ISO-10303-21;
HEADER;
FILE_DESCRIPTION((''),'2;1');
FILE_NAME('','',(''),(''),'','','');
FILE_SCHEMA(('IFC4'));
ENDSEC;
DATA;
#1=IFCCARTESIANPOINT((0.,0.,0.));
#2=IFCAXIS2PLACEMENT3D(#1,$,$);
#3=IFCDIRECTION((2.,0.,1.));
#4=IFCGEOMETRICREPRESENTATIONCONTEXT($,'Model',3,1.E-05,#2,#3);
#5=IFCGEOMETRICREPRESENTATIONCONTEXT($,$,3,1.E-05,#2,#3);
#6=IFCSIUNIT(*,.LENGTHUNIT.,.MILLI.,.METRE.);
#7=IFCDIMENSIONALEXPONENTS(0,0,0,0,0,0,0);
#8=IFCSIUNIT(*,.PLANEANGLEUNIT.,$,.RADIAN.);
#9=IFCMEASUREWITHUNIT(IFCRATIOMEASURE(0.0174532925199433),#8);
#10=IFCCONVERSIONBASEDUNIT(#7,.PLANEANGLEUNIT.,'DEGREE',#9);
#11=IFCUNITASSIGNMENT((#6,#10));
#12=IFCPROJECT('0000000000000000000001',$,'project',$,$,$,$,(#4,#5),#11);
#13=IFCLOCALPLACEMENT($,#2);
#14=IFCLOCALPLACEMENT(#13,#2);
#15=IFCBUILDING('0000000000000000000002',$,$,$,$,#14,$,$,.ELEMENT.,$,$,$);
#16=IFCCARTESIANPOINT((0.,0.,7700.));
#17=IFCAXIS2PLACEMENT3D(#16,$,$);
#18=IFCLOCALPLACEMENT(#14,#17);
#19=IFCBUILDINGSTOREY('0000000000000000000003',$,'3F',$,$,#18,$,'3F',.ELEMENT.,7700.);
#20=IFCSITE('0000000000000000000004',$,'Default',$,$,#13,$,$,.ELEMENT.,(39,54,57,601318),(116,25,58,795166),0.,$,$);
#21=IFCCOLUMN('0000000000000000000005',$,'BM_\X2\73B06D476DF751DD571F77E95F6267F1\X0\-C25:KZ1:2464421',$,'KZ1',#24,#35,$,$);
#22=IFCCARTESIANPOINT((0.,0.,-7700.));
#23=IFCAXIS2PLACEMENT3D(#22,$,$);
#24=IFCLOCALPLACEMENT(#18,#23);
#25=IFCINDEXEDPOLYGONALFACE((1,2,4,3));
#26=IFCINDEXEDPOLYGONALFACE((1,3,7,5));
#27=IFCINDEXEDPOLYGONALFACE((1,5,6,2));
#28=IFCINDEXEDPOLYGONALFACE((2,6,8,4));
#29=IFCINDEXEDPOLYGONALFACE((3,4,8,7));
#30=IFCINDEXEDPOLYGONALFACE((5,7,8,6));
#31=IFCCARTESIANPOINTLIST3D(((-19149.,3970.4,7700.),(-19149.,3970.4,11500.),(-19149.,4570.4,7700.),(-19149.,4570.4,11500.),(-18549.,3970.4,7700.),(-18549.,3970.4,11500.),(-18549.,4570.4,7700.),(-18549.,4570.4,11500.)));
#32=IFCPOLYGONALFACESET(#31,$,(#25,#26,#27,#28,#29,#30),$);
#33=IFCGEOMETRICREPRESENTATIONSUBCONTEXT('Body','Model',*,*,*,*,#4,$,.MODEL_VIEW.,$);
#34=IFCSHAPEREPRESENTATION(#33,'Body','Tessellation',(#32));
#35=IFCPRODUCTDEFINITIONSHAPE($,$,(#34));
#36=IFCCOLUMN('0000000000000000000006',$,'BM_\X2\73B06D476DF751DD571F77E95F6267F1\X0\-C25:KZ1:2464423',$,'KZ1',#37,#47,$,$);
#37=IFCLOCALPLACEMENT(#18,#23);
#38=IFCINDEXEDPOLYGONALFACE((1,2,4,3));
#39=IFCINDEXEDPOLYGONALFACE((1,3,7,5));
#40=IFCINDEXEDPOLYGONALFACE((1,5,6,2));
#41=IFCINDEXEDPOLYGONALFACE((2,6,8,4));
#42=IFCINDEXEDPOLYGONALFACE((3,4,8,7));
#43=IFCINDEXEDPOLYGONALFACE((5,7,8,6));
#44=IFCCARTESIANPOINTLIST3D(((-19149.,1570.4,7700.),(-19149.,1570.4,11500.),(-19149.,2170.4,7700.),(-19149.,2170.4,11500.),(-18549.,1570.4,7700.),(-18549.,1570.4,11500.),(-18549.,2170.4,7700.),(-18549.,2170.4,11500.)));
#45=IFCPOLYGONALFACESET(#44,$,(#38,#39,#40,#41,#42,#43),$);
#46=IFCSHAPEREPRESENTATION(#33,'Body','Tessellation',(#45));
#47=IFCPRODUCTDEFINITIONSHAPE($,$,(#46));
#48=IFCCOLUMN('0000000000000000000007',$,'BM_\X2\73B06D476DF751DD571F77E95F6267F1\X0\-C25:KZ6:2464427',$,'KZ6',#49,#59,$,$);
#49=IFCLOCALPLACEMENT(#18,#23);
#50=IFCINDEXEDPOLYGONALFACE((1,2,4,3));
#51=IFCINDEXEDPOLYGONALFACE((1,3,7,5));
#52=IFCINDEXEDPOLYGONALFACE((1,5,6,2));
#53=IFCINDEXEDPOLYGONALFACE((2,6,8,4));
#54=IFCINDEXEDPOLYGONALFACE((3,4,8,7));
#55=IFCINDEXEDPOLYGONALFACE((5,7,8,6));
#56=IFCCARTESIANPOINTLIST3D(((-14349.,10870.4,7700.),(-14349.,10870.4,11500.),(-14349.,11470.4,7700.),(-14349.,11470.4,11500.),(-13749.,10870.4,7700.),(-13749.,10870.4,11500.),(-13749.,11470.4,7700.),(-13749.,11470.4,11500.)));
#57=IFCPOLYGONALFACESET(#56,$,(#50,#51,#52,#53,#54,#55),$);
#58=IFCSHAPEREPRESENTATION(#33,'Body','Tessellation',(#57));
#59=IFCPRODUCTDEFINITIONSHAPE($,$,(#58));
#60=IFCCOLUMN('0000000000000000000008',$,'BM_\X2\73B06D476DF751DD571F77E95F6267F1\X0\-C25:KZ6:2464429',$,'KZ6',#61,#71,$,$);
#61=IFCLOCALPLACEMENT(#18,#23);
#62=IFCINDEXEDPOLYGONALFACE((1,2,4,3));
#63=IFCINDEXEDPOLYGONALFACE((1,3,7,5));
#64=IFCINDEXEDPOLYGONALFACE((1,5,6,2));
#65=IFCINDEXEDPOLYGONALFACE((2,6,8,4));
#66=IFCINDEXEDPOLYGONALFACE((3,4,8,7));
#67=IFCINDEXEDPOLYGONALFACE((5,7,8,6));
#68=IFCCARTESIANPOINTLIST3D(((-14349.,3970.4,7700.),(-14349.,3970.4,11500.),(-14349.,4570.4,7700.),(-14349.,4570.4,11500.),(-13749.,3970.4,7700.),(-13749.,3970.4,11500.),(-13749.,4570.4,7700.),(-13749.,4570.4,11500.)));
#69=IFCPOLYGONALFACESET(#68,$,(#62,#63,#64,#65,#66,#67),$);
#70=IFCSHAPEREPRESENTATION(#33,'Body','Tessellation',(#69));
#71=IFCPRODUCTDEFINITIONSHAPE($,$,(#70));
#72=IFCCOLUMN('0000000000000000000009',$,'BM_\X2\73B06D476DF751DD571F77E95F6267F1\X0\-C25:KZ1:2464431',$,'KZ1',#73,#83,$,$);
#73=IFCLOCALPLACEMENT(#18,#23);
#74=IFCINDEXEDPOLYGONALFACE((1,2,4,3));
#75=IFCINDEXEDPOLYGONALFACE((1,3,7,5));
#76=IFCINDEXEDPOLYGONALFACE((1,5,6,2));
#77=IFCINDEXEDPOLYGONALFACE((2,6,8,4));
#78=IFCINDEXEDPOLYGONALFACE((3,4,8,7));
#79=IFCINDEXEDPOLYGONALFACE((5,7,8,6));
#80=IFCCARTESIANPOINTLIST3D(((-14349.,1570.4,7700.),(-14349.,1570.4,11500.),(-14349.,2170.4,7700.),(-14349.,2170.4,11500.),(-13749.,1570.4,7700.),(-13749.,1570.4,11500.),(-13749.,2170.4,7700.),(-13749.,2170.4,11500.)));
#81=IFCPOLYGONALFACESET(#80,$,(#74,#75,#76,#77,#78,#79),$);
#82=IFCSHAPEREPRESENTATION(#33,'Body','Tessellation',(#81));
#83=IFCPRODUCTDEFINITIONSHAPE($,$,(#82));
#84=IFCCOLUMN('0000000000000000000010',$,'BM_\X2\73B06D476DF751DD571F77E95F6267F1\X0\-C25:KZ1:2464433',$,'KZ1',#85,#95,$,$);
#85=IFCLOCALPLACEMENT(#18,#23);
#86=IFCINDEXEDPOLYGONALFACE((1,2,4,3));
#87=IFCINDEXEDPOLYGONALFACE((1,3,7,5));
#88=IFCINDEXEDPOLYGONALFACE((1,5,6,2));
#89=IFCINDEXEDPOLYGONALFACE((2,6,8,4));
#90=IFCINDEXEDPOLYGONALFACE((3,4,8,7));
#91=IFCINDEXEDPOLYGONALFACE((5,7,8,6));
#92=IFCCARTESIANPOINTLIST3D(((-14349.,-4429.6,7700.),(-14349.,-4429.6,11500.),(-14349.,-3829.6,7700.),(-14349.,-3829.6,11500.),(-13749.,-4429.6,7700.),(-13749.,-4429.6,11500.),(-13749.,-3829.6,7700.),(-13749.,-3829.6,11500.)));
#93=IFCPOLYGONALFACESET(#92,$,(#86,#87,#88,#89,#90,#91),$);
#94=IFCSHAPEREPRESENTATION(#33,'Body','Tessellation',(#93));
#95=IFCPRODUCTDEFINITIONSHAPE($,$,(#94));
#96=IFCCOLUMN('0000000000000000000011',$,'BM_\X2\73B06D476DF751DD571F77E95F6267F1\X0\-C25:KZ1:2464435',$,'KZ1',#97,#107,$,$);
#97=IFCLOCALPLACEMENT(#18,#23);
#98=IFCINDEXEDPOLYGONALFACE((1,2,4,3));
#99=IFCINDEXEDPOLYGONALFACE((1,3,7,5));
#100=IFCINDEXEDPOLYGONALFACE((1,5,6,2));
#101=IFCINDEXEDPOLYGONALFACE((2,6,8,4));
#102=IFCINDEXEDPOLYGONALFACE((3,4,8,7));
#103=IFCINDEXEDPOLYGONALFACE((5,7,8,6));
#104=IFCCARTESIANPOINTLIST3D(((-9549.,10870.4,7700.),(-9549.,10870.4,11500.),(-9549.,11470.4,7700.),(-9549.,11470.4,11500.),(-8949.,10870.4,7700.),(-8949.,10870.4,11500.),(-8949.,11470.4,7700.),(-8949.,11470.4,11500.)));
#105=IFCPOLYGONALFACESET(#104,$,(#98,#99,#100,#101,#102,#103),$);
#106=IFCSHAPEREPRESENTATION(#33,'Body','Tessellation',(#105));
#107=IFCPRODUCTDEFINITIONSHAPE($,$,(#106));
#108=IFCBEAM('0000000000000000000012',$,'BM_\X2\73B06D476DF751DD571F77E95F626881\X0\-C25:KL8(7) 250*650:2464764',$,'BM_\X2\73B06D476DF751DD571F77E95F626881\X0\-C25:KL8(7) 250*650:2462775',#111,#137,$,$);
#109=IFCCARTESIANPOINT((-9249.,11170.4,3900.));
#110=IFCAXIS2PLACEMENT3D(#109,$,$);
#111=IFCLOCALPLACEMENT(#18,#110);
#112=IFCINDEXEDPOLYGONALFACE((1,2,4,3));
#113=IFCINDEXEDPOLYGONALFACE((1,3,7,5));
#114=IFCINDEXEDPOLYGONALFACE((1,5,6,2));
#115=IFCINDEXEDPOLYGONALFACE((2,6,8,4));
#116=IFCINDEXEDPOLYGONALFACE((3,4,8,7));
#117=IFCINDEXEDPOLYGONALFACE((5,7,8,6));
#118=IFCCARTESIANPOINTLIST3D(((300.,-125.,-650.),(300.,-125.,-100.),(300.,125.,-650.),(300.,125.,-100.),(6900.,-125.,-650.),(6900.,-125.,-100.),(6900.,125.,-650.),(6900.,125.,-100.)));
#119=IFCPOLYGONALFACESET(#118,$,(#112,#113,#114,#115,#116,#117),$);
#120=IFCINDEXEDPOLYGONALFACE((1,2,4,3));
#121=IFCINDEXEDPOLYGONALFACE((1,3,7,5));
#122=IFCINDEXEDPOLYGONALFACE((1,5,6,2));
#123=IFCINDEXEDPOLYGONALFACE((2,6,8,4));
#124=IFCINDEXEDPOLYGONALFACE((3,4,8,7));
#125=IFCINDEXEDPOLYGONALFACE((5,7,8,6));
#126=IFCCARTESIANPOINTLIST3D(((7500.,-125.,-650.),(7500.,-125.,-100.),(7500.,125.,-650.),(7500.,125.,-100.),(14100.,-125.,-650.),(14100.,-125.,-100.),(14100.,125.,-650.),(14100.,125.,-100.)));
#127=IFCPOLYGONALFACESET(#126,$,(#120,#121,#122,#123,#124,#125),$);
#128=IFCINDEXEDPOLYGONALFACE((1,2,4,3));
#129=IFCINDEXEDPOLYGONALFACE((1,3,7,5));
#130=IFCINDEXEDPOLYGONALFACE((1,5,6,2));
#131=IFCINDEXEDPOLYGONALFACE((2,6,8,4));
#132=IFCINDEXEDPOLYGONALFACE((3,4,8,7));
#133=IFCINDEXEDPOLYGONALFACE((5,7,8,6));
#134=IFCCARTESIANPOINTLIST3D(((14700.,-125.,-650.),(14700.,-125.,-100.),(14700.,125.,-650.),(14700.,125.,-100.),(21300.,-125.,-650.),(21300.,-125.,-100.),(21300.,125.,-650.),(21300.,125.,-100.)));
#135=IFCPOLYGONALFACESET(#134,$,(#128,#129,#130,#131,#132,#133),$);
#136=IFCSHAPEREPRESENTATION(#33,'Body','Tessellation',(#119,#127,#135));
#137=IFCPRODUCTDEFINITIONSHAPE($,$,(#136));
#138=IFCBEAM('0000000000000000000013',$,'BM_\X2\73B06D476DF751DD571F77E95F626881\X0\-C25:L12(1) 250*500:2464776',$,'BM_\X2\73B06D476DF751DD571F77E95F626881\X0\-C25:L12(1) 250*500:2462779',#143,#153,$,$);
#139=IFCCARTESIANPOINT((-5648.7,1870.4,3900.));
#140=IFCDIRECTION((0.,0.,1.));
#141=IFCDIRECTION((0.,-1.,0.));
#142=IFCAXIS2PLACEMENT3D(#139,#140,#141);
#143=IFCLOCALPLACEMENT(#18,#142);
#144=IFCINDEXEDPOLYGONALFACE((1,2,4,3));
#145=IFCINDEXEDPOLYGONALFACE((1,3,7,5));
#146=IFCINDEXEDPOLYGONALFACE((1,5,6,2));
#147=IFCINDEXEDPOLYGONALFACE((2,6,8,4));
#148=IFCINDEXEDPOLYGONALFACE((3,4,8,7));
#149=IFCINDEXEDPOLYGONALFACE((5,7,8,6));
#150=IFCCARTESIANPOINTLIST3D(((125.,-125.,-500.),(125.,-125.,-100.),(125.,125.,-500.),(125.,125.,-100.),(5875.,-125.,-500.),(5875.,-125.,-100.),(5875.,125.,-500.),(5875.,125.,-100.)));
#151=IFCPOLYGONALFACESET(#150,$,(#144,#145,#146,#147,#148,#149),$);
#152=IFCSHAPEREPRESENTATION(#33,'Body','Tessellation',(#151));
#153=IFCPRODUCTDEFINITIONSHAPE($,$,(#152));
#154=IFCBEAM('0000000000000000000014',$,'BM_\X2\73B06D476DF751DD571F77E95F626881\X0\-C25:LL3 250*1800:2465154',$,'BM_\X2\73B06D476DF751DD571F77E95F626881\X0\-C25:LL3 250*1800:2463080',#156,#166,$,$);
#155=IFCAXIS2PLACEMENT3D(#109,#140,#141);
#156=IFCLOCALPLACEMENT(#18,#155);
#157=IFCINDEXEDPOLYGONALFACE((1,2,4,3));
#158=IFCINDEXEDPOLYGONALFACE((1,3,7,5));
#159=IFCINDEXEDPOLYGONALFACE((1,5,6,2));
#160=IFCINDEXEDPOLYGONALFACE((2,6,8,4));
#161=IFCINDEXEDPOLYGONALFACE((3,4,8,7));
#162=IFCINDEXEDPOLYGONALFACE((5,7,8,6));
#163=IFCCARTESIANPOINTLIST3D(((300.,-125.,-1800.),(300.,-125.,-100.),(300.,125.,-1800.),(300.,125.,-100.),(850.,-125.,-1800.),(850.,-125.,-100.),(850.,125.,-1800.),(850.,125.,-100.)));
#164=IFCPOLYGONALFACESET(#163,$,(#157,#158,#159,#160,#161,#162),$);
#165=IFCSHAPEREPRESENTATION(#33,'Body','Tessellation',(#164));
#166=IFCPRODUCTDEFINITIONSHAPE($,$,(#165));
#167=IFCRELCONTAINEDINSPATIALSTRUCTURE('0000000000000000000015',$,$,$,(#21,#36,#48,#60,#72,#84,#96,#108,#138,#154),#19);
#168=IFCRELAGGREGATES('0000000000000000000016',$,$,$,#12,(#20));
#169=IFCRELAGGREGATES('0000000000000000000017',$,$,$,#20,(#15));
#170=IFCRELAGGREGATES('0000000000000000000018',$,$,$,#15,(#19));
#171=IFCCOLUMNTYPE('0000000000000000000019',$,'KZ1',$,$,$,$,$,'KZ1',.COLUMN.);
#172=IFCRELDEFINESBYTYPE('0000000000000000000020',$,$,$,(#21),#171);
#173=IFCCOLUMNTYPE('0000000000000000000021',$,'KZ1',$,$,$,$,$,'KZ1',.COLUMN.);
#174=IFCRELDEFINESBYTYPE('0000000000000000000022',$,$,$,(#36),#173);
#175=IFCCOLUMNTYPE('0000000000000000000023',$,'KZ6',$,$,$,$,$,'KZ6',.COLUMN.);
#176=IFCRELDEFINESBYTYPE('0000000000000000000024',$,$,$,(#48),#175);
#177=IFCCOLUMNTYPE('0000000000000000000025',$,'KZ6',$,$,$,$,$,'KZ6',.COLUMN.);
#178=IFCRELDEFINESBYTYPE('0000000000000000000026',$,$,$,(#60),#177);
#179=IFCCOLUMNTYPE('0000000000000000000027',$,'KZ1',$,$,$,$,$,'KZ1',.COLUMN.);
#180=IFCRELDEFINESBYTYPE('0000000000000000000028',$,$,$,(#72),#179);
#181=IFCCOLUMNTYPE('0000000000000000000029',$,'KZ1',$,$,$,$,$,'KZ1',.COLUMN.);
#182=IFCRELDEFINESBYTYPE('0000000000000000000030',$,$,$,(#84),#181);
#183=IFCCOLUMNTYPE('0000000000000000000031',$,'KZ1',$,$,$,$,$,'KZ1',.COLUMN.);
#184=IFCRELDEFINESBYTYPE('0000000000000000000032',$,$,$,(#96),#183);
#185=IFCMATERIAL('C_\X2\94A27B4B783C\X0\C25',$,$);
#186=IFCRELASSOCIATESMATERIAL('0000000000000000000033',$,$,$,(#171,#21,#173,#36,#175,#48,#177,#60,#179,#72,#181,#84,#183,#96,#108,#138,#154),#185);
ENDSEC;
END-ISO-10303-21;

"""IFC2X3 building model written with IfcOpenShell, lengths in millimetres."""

from ifc_helpers import new_model, entity, si_unit, converted_unit, direction, frame, frame_2d, origin, origin_2d_with_axis, place, context, subcontext, project, spatial, rectangle, extrude, source, transform, mapped, material, type_object, type_shapes, element, save


model = new_model("IFC2X3")

# Units and contexts
model_context = context("Model", 3, precision=1e-05, world=origin(), true_north=direction((2.0, 0.0, 1.0)))
context_of_model = context(None, 3, precision=1e-05, world=origin(), true_north=direction((2.0, 0.0, 1.0)))
body_context = subcontext(model_context, "Body", "Model", "MODEL_VIEW")
ifc_project = project(units=[si_unit("LENGTHUNIT", "METRE", prefix="MILLI"), converted_unit("PLANEANGLEUNIT", "DEGREE", entity("IfcRatioMeasure", 0.0174532925199433), si_unit("PLANEANGLEUNIT", "RADIAN"), dimensions=[0, 0, 0, 0, 0, 0, 0])], contexts=[model_context, context_of_model])

# Site, building, storey
site_placement = place(None, origin())
site = spatial("IfcSite", under=ifc_project, at=site_placement, Name="Default", CompositionType="ELEMENT", RefLatitude=(39, 54, 57, 601318), RefLongitude=(116, 25, 58, 795166), RefElevation=0.0)
building_placement = place(site_placement, origin())
building = spatial("IfcBuilding", under=site, at=building_placement, CompositionType="ELEMENT")
storey_placement = place(building_placement, frame((0.0, 0.0, 7700.0)))
storey = spatial("IfcBuildingStorey", under=building, at=storey_placement, Name="3F", LongName="3F", CompositionType="ELEMENT", Elevation=7700.0)

# Columns
ifc_material = material(Name="C_钢筋砼C25")
column_type_1 = type_object("IfcColumnType", Name="KZ1", ElementType="KZ1", PredefinedType="COLUMN", material=ifc_material)
shared_shape_1 = source(origin(), body_context, "Body", "SweptSolid", [
    extrude(rectangle(XDim=600.0, YDim=600.0, at=frame_2d((0.0, 0.0), x_axis=(1.0, 0.0))), frame((-18849.0, 4270.4, 7700.0), z_axis=(0.0, 0.0, 1.0), x_axis=(-1.0, 0.0, 0.0)), (0.0, 0.0, 1.0), 3800.0),
])
type_shapes(column_type_1, [shared_shape_1])
column_1_placement = place(storey_placement, frame((0.0, 0.0, -7700.0)))
element("IfcColumn", 1, at=column_1_placement, inside=storey, type_object=column_type_1, material=ifc_material, Name="BM_现浇混凝土矩形柱-C25:KZ1:2464421", ObjectType="KZ1", context=body_context, shape_type="MappedRepresentation", body=[
    mapped(shared_shape_1, transform((0.0, 0.0, 0.0), scale=1.0)),
])
column_type_2 = type_object("IfcColumnType", Name="KZ1", ElementType="KZ1", PredefinedType="COLUMN", material=ifc_material)
shared_shape_2 = source(origin(), body_context, "Body", "SweptSolid", [
    extrude(rectangle(XDim=600.0, YDim=600.0, at=frame_2d((0.0, 0.0), x_axis=(1.0, 0.0))), frame((-18849.0, 1870.4, 7700.0), z_axis=(0.0, 0.0, 1.0), x_axis=(-1.0, 0.0, 0.0)), (0.0, 0.0, 1.0), 3800.0),
])
type_shapes(column_type_2, [shared_shape_2])
column_2_placement = place(storey_placement, frame((0.0, 0.0, -7700.0)))
element("IfcColumn", 2, at=column_2_placement, inside=storey, type_object=column_type_2, material=ifc_material, Name="BM_现浇混凝土矩形柱-C25:KZ1:2464423", ObjectType="KZ1", context=body_context, shape_type="MappedRepresentation", body=[
    mapped(shared_shape_2, transform((0.0, 0.0, 0.0), scale=1.0)),
])
column_type_3 = type_object("IfcColumnType", Name="KZ6", ElementType="KZ6", PredefinedType="COLUMN", material=ifc_material)
shared_shape_3 = source(origin(), body_context, "Body", "SweptSolid", [
    extrude(rectangle(XDim=600.0, YDim=600.0, at=frame_2d((0.0, 0.0), x_axis=(1.0, 0.0))), frame((-14049.0, 11170.4, 7700.0), z_axis=(0.0, 0.0, 1.0), x_axis=(-1.0, 0.0, 0.0)), (0.0, 0.0, 1.0), 3800.0),
])
type_shapes(column_type_3, [shared_shape_3])
column_3_placement = place(storey_placement, frame((0.0, 0.0, -7700.0)))
element("IfcColumn", 3, at=column_3_placement, inside=storey, type_object=column_type_3, material=ifc_material, Name="BM_现浇混凝土矩形柱-C25:KZ6:2464427", ObjectType="KZ6", context=body_context, shape_type="MappedRepresentation", body=[
    mapped(shared_shape_3, transform((0.0, 0.0, 0.0), scale=1.0)),
])
column_type_4 = type_object("IfcColumnType", Name="KZ6", ElementType="KZ6", PredefinedType="COLUMN", material=ifc_material)
shared_shape_4 = source(origin(), body_context, "Body", "SweptSolid", [
    extrude(rectangle(XDim=600.0, YDim=600.0, at=frame_2d((0.0, 0.0), x_axis=(1.0, 0.0))), frame((-14049.0, 4270.4, 7700.0), z_axis=(0.0, 0.0, 1.0), x_axis=(-1.0, 0.0, 0.0)), (0.0, 0.0, 1.0), 3800.0),
])
type_shapes(column_type_4, [shared_shape_4])
column_4_placement = place(storey_placement, frame((0.0, 0.0, -7700.0)))
element("IfcColumn", 4, at=column_4_placement, inside=storey, type_object=column_type_4, material=ifc_material, Name="BM_现浇混凝土矩形柱-C25:KZ6:2464429", ObjectType="KZ6", context=body_context, shape_type="MappedRepresentation", body=[
    mapped(shared_shape_4, transform((0.0, 0.0, 0.0), scale=1.0)),
])
column_type_5 = type_object("IfcColumnType", Name="KZ1", ElementType="KZ1", PredefinedType="COLUMN", material=ifc_material)
shared_shape_5 = source(origin(), body_context, "Body", "SweptSolid", [
    extrude(rectangle(XDim=600.0, YDim=600.0, at=frame_2d((0.0, 0.0), x_axis=(1.0, 0.0))), frame((-14049.0, 1870.4, 7700.0), z_axis=(0.0, 0.0, 1.0), x_axis=(-1.0, 0.0, 0.0)), (0.0, 0.0, 1.0), 3800.0),
])
type_shapes(column_type_5, [shared_shape_5])
column_5_placement = place(storey_placement, frame((0.0, 0.0, -7700.0)))
element("IfcColumn", 5, at=column_5_placement, inside=storey, type_object=column_type_5, material=ifc_material, Name="BM_现浇混凝土矩形柱-C25:KZ1:2464431", ObjectType="KZ1", context=body_context, shape_type="MappedRepresentation", body=[
    mapped(shared_shape_5, transform((0.0, 0.0, 0.0), scale=1.0)),
])
column_type_6 = type_object("IfcColumnType", Name="KZ1", ElementType="KZ1", PredefinedType="COLUMN", material=ifc_material)
shared_shape_6 = source(origin(), body_context, "Body", "SweptSolid", [
    extrude(rectangle(XDim=600.0, YDim=600.0, at=frame_2d((0.0, 0.0), x_axis=(1.0, 0.0))), frame((-14049.0, -4129.6, 7700.0), z_axis=(0.0, 0.0, 1.0), x_axis=(-1.0, 0.0, 0.0)), (0.0, 0.0, 1.0), 3800.0),
])
type_shapes(column_type_6, [shared_shape_6])
column_6_placement = place(storey_placement, frame((0.0, 0.0, -7700.0)))
element("IfcColumn", 6, at=column_6_placement, inside=storey, type_object=column_type_6, material=ifc_material, Name="BM_现浇混凝土矩形柱-C25:KZ1:2464433", ObjectType="KZ1", context=body_context, shape_type="MappedRepresentation", body=[
    mapped(shared_shape_6, transform((0.0, 0.0, 0.0), scale=1.0)),
])
column_type_7 = type_object("IfcColumnType", Name="KZ1", ElementType="KZ1", PredefinedType="COLUMN", material=ifc_material)
shared_shape_7 = source(origin(), body_context, "Body", "SweptSolid", [
    extrude(rectangle(XDim=600.0, YDim=600.0, at=frame_2d((0.0, 0.0), x_axis=(1.0, 0.0))), frame((-9249.0, 11170.4, 7700.0), z_axis=(0.0, 0.0, 1.0), x_axis=(-1.0, 0.0, 0.0)), (0.0, 0.0, 1.0), 3800.0),
])
type_shapes(column_type_7, [shared_shape_7])
column_7_placement = place(storey_placement, frame((0.0, 0.0, -7700.0)))
element("IfcColumn", 7, at=column_7_placement, inside=storey, type_object=column_type_7, material=ifc_material, Name="BM_现浇混凝土矩形柱-C25:KZ1:2464435", ObjectType="KZ1", context=body_context, shape_type="MappedRepresentation", body=[
    mapped(shared_shape_7, transform((0.0, 0.0, 0.0), scale=1.0)),
])

# Beams
beam_1_placement = place(storey_placement, frame((-9249.0, 11170.4, 3900.0)))
element("IfcBeam", 8, at=beam_1_placement, inside=storey, material=ifc_material, Name="BM_现浇混凝土矩形梁-C25:KL8(7) 250*650:2464764", ObjectType="BM_现浇混凝土矩形梁-C25:KL8(7) 250*650:2462775", context=body_context, shape_type="SweptSolid", body=[
    extrude(rectangle(XDim=550.0, YDim=250.0, at=origin_2d_with_axis()), frame((300.0, 0.0, -375.0), z_axis=(1.0, 0.0, 0.0), x_axis=(0.0, 0.0, 1.0)), (0.0, 0.0, 1.0), 6600.0),
    extrude(rectangle(XDim=550.0, YDim=250.0, at=frame_2d((0.0, 0.0), x_axis=(1.0, 0.0))), frame((7500.0, 0.0, -375.0), z_axis=(1.0, 0.0, 0.0), x_axis=(0.0, 0.0, 1.0)), (0.0, 0.0, 1.0), 6600.0),
    extrude(rectangle(XDim=550.0, YDim=250.0, at=frame_2d((-45.0, -25.0), x_axis=(1.0, 0.0))), frame((14700.0, -25.0, -330.0), z_axis=(1.0, 0.0, 0.0), x_axis=(0.0, 0.0, 1.0)), (0.0, 0.0, 1.0), 6600.0),
])
beam_2_placement = place(storey_placement, frame((-5648.7, 1870.4, 3900.0), z_axis=(0.0, 0.0, 1.0), x_axis=(0.0, -1.0, 0.0)))
element("IfcBeam", 9, at=beam_2_placement, inside=storey, material=ifc_material, Name="BM_现浇混凝土矩形梁-C25:L12(1) 250*500:2464776", ObjectType="BM_现浇混凝土矩形梁-C25:L12(1) 250*500:2462779", context=body_context, shape_type="SweptSolid", body=[
    extrude(rectangle(XDim=400.0, YDim=250.0, at=frame_2d((0.0, 0.0), x_axis=(1.0, 0.0))), frame((125.0, 0.0, -300.0), z_axis=(1.0, 0.0, 0.0), x_axis=(0.0, 0.0, -1.0)), (0.0, 0.0, 1.0), 5750.0),
])
beam_3_placement = place(storey_placement, frame((-9249.0, 11170.4, 3900.0), z_axis=(0.0, 0.0, 1.0), x_axis=(0.0, -1.0, 0.0)))
element("IfcBeam", 10, at=beam_3_placement, inside=storey, material=ifc_material, Name="BM_现浇混凝土矩形梁-C25:LL3 250*1800:2465154", ObjectType="BM_现浇混凝土矩形梁-C25:LL3 250*1800:2463080", context=body_context, shape_type="SweptSolid", body=[
    extrude(rectangle(XDim=1700.0, YDim=250.0, at=frame_2d((0.0, 0.0), x_axis=(1.0, 0.0))), frame((300.0, 0.0, -950.0), z_axis=(1.0, 0.0, 0.0), x_axis=(0.0, 0.0, -1.0)), (0.0, 0.0, 1.0), 550.0),
])

save(model, "model.ifc")
